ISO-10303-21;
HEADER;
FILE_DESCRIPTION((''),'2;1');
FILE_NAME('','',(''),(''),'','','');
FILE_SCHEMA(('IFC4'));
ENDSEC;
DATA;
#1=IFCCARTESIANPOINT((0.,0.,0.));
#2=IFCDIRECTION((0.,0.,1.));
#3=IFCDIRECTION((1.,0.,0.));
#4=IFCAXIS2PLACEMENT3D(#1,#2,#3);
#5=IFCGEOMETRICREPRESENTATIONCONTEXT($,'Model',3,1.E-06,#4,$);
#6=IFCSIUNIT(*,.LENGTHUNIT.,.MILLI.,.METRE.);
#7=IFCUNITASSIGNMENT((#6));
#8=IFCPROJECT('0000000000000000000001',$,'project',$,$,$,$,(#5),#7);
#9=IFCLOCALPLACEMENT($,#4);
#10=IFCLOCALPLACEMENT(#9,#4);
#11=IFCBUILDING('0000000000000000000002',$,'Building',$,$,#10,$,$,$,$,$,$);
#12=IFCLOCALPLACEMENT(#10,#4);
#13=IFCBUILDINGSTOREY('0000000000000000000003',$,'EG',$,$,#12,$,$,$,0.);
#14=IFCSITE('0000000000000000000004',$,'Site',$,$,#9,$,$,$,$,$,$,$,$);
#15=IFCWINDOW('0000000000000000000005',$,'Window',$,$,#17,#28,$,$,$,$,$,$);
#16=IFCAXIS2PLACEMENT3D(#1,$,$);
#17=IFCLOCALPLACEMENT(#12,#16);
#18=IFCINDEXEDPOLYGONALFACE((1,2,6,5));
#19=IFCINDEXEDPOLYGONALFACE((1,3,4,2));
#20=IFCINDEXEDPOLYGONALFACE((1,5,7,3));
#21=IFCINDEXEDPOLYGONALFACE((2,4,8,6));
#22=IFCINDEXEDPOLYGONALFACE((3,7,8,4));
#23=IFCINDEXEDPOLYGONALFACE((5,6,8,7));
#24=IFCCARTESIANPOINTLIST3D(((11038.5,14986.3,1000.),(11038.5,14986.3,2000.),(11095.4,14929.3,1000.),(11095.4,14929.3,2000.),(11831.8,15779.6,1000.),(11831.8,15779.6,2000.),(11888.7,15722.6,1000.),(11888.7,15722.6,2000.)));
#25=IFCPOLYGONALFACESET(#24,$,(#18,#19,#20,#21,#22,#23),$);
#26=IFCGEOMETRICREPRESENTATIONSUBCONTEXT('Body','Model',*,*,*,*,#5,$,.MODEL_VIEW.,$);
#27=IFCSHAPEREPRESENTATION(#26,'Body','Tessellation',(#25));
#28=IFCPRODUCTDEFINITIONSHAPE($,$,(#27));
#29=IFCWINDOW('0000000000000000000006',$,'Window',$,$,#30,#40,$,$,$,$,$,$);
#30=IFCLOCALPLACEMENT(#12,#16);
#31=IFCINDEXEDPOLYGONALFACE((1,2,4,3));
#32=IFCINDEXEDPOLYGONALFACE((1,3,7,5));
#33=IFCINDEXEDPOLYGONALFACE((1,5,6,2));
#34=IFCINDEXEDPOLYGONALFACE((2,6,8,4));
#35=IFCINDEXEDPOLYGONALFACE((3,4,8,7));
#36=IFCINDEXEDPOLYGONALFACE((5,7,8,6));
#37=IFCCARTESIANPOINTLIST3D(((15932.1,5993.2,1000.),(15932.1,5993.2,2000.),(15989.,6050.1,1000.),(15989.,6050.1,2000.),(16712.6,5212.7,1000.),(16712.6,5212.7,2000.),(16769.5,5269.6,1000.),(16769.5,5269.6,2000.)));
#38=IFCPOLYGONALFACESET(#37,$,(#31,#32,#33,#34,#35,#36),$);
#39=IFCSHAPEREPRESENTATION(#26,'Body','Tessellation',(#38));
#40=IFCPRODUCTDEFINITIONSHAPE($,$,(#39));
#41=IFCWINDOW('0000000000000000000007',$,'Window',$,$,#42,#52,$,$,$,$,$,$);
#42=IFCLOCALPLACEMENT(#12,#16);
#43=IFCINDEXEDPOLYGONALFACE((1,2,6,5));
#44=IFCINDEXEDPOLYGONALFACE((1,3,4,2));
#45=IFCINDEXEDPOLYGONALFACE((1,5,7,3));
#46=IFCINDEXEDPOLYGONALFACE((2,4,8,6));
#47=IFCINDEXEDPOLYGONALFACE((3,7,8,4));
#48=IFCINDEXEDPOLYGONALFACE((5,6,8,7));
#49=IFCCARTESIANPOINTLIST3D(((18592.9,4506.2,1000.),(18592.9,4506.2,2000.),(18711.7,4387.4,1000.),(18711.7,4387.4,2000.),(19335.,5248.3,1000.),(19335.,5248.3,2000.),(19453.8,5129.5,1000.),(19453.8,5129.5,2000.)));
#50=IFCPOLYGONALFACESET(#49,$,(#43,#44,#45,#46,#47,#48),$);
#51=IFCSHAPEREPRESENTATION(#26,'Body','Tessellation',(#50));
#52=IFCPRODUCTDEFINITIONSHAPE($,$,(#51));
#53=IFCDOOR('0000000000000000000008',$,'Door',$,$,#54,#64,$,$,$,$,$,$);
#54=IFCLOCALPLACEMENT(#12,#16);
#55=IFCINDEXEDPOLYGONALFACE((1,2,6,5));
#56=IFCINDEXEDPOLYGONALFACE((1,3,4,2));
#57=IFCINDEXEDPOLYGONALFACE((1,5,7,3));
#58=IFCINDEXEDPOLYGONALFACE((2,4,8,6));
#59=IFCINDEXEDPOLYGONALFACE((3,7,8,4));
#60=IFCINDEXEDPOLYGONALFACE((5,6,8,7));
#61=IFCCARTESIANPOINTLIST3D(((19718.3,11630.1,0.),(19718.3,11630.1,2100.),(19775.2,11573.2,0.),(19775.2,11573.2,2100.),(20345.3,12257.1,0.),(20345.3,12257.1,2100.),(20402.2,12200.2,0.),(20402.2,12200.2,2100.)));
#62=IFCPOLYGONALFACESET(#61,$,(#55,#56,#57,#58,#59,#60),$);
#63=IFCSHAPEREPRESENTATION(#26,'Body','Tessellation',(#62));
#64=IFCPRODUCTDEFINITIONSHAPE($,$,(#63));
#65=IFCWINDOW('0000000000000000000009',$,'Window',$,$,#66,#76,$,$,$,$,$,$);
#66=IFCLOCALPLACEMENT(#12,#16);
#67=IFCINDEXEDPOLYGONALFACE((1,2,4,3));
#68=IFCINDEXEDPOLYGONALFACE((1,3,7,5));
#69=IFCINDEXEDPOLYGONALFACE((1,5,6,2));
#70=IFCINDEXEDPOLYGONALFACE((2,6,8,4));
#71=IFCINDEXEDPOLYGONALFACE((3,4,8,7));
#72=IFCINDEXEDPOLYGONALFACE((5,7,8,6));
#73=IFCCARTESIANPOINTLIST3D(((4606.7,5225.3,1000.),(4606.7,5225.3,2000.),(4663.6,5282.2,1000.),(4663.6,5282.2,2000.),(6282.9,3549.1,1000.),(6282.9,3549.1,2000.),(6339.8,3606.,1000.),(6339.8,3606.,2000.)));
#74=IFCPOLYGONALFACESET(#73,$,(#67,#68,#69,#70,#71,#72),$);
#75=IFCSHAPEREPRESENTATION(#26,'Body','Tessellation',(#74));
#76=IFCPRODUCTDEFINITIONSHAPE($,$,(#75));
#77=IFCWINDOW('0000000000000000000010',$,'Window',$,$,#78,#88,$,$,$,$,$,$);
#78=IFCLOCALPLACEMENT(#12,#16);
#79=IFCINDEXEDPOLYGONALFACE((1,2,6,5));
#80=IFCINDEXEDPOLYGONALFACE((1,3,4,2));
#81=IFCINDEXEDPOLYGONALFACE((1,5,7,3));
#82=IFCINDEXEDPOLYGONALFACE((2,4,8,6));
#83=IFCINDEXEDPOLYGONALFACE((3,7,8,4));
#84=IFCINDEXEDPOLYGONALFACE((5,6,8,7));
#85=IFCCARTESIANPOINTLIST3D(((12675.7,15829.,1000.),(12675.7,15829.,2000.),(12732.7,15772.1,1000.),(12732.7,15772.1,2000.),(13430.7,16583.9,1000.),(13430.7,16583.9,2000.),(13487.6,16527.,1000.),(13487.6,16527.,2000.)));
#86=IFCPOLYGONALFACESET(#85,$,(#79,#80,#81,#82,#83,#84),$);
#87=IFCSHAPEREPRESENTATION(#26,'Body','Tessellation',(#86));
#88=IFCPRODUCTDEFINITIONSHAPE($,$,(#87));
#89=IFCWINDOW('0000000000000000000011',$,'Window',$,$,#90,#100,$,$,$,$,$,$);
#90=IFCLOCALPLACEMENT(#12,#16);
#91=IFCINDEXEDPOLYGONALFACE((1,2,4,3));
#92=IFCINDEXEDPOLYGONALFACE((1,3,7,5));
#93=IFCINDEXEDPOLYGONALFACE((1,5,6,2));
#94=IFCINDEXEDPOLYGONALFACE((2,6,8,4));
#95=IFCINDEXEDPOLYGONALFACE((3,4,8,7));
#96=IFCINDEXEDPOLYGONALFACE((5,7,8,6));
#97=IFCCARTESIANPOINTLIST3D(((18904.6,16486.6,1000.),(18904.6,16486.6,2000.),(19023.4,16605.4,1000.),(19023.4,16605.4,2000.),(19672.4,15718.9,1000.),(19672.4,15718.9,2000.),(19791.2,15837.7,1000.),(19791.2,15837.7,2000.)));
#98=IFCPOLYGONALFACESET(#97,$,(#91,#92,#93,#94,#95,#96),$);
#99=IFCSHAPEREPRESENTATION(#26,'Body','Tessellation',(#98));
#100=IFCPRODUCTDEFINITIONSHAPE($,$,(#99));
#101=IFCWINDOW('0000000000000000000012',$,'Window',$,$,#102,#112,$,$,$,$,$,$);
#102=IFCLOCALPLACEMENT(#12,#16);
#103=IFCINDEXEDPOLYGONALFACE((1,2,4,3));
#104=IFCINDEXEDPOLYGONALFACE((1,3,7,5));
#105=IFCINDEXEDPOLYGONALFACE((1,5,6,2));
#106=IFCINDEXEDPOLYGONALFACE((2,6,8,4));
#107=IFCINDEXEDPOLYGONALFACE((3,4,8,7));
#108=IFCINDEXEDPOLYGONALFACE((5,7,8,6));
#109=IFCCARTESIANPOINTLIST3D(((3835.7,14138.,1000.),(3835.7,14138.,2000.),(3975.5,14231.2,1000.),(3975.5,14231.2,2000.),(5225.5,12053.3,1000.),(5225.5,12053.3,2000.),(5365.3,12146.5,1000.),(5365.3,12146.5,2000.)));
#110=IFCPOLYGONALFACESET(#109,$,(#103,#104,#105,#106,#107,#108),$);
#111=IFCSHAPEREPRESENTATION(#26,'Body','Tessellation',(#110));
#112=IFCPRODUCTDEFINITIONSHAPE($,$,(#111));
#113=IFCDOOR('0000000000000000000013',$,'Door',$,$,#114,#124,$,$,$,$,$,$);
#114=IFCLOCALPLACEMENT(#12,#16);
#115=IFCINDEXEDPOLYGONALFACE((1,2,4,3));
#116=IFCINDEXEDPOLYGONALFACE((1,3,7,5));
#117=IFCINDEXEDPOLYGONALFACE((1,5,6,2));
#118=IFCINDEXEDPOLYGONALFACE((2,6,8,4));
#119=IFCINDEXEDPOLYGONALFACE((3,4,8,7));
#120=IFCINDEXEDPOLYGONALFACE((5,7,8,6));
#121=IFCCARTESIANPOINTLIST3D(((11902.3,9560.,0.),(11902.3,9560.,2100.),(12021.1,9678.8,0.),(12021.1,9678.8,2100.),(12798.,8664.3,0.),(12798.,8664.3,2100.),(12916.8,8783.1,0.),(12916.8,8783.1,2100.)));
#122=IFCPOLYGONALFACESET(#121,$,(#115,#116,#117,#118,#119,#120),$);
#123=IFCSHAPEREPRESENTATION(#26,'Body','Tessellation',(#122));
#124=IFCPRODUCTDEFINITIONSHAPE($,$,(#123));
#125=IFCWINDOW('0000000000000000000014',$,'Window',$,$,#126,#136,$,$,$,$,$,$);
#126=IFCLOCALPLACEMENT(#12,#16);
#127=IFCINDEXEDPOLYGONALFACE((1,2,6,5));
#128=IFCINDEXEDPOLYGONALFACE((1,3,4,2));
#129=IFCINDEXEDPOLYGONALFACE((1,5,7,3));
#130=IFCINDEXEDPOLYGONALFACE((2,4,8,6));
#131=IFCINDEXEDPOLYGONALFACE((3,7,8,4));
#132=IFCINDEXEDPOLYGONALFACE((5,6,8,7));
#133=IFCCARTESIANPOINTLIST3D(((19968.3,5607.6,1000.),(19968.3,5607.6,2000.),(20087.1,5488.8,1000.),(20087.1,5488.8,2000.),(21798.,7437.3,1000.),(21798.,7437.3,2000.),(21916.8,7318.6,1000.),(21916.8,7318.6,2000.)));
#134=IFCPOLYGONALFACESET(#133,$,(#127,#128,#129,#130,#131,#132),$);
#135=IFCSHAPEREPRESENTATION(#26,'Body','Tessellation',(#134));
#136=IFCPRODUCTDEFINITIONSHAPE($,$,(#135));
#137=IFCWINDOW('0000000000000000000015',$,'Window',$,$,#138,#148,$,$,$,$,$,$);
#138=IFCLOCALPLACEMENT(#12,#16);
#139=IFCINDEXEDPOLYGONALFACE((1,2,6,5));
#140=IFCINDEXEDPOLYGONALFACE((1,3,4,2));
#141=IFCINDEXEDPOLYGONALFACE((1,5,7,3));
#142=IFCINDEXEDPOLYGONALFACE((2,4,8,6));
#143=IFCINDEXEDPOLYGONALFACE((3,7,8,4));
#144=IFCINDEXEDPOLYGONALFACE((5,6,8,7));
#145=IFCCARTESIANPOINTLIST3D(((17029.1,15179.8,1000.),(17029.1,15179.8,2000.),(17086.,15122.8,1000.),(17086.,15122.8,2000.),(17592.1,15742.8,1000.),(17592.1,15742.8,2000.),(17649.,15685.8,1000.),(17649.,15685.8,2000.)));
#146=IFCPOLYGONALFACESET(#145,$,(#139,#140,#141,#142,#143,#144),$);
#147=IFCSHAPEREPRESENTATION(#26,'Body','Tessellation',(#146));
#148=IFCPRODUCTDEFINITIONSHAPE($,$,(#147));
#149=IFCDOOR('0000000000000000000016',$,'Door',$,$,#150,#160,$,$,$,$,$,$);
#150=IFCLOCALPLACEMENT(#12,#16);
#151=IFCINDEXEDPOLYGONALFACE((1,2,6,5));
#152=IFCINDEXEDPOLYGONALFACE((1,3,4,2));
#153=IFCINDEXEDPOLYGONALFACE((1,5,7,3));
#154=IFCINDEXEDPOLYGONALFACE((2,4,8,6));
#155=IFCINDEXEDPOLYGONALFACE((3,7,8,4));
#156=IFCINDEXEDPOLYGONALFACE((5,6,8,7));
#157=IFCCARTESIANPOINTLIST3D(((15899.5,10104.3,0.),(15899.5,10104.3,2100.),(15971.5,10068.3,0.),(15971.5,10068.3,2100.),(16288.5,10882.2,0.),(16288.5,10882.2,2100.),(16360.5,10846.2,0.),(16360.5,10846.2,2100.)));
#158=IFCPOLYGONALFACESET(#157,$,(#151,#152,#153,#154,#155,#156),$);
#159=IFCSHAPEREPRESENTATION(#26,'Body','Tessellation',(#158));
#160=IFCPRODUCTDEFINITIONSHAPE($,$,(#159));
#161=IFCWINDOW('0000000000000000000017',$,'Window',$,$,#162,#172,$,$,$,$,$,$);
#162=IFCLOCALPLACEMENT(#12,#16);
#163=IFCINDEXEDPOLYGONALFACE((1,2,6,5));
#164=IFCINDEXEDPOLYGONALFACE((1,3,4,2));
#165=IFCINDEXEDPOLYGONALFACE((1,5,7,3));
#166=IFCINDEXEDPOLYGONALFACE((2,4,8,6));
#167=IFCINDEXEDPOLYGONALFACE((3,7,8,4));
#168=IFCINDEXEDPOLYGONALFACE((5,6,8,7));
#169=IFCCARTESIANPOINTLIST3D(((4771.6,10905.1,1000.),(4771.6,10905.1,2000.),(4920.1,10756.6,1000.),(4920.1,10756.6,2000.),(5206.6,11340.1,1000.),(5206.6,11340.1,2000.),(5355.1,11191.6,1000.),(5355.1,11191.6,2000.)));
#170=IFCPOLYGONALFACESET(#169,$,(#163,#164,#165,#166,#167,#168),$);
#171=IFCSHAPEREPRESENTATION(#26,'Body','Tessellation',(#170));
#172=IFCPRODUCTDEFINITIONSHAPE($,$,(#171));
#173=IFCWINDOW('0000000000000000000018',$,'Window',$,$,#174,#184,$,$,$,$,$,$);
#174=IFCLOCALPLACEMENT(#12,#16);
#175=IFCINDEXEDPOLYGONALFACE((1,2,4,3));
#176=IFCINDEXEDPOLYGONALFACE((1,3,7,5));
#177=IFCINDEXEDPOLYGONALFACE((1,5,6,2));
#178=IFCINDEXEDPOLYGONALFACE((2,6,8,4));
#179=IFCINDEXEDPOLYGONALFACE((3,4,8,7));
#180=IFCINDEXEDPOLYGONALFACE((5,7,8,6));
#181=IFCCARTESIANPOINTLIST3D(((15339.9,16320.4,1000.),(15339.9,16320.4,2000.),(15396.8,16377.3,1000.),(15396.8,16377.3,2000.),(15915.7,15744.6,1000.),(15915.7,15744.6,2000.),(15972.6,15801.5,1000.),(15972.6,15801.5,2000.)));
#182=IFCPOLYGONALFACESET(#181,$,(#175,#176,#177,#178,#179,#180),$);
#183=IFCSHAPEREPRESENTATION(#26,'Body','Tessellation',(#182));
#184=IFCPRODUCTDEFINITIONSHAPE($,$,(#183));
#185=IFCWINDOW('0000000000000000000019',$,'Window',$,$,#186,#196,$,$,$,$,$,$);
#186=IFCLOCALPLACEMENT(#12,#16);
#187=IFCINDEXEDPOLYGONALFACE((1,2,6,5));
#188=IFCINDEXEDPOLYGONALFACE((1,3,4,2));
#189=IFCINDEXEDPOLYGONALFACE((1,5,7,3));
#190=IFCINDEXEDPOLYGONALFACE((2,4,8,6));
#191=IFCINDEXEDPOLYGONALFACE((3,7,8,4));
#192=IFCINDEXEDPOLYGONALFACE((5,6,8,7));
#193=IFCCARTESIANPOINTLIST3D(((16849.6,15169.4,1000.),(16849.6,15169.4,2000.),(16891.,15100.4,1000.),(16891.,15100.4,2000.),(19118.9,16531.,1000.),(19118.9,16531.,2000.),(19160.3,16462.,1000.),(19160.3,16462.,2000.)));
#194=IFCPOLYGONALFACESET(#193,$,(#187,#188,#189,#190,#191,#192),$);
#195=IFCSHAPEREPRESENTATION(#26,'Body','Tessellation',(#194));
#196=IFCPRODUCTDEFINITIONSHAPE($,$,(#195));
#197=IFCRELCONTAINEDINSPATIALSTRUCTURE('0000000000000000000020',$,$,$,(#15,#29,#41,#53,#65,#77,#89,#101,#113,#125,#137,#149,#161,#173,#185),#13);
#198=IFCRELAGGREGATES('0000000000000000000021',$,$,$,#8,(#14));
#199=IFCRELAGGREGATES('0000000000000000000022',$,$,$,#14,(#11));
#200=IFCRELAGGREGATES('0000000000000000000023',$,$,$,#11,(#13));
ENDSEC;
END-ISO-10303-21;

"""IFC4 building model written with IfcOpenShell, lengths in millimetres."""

from ifc_helpers import new_model, si_unit, frame, origin_with_axes, place, context, subcontext, project, spatial, rectangle, extrude, element, save


model = new_model("IFC4")

# Units and contexts
model_context = context("Model", 3, precision=1e-06, world=origin_with_axes())
body_context = subcontext(model_context, "Body", "Model", "MODEL_VIEW")
ifc_project = project(units=[si_unit("LENGTHUNIT", "METRE", prefix="MILLI")], contexts=[model_context])

# Site, building, storey
site_placement = place(None, origin_with_axes())
site = spatial("IfcSite", under=ifc_project, at=site_placement, Name="Site")
building_placement = place(site_placement, origin_with_axes())
building = spatial("IfcBuilding", under=site, at=building_placement, Name="Building")
storey_placement = place(building_placement, origin_with_axes())
storey = spatial("IfcBuildingStorey", under=building, at=storey_placement, Name="EG", Elevation=0.0)

# Windows
window_1_placement = place(storey_placement, origin_with_axes())
element("IfcWindow", 1, at=window_1_placement, inside=storey, Name="Window", context=body_context, shape_type="SweptSolid", body=[
    extrude(rectangle(XDim=1121.9, YDim=80.5), frame((11463.6, 15354.5, 1000.0), z_axis=(0.0, 0.0, 1.0), x_axis=(-0.707107, -0.707107, 0.0)), (0.0, 0.0, 1.0), 1000.0),
])
window_2_placement = place(storey_placement, origin_with_axes())
element("IfcWindow", 2, at=window_2_placement, inside=storey, Name="Window", context=body_context, shape_type="SweptSolid", body=[
    extrude(rectangle(XDim=1103.8, YDim=80.5), frame((16350.8, 5631.4, 1000.0), z_axis=(0.0, 0.0, 1.0), x_axis=(-0.707107, 0.707107, 0.0)), (0.0, 0.0, 1.0), 1000.0),
])
window_3_placement = place(storey_placement, origin_with_axes())
element("IfcWindow", 3, at=window_3_placement, inside=storey, Name="Window", context=body_context, shape_type="SweptSolid", body=[
    extrude(rectangle(XDim=1049.5, YDim=168.0), frame((19023.3, 4817.9, 1000.0), z_axis=(0.0, 0.0, 1.0), x_axis=(-0.707107, -0.707107, 0.0)), (0.0, 0.0, 1.0), 1000.0),
])

# Door
door_1_placement = place(storey_placement, origin_with_axes())
element("IfcDoor", 4, at=door_1_placement, inside=storey, Name="Door", context=body_context, shape_type="SweptSolid", body=[
    extrude(rectangle(XDim=886.7, YDim=80.5), frame((20060.3, 11915.1, 0.0), z_axis=(0.0, 0.0, 1.0), x_axis=(0.707107, 0.707107, 0.0)), (0.0, 0.0, 1.0), 2100.0),
])

# Windows
window_4_placement = place(storey_placement, origin_with_axes())
element("IfcWindow", 5, at=window_4_placement, inside=storey, Name="Window", context=body_context, shape_type="SweptSolid", body=[
    extrude(rectangle(XDim=2370.5, YDim=80.5), frame((5473.2, 4415.6, 1000.0), z_axis=(0.0, 0.0, 1.0), x_axis=(0.707107, -0.707107, 0.0)), (0.0, 0.0, 1.0), 1000.0),
])
window_5_placement = place(storey_placement, origin_with_axes())
element("IfcWindow", 6, at=window_5_placement, inside=storey, Name="Window", context=body_context, shape_type="SweptSolid", body=[
    extrude(rectangle(XDim=1067.6, YDim=80.5), frame((13081.7, 16178.0, 1000.0), z_axis=(0.0, 0.0, 1.0), x_axis=(0.707107, 0.707107, 0.0)), (0.0, 0.0, 1.0), 1000.0),
])
window_6_placement = place(storey_placement, origin_with_axes())
element("IfcWindow", 7, at=window_6_placement, inside=storey, Name="Window", context=body_context, shape_type="SweptSolid", body=[
    extrude(rectangle(XDim=1085.7, YDim=168.0), frame((19347.9, 16162.1, 1000.0), z_axis=(0.0, 0.0, 1.0), x_axis=(-0.707107, 0.707107, 0.0)), (0.0, 0.0, 1.0), 1000.0),
])
window_7_placement = place(storey_placement, origin_with_axes())
element("IfcWindow", 8, at=window_7_placement, inside=storey, Name="Window", context=body_context, shape_type="SweptSolid", body=[
    extrude(rectangle(XDim=2505.5, YDim=168.0), frame((4600.5, 13142.3, 1000.0), z_axis=(0.0, 0.0, 1.0), x_axis=(-0.5547, 0.83205, 0.0)), (0.0, 0.0, 1.0), 1000.0),
])

# Door
door_2_placement = place(storey_placement, origin_with_axes())
element("IfcDoor", 9, at=door_2_placement, inside=storey, Name="Door", context=body_context, shape_type="SweptSolid", body=[
    extrude(rectangle(XDim=1266.7, YDim=168.0), frame((12409.5, 9171.5, 0.0), z_axis=(0.0, 0.0, 1.0), x_axis=(0.707107, -0.707107, 0.0)), (0.0, 0.0, 1.0), 2100.0),
])

# Windows
window_8_placement = place(storey_placement, origin_with_axes())
element("IfcWindow", 10, at=window_8_placement, inside=storey, Name="Window", context=body_context, shape_type="SweptSolid", body=[
    extrude(rectangle(XDim=2587.6, YDim=168.0), frame((20942.5, 6463.1, 1000.0), z_axis=(0.0, 0.0, 1.0), x_axis=(-0.707107, -0.707107, 0.0)), (0.0, 0.0, 1.0), 1000.0),
])
window_9_placement = place(storey_placement, origin_with_axes())
element("IfcWindow", 11, at=window_9_placement, inside=storey, Name="Window", context=body_context, shape_type="SweptSolid", body=[
    extrude(rectangle(XDim=796.2, YDim=80.5), frame((17339.0, 15432.8, 1000.0), z_axis=(0.0, 0.0, 1.0), x_axis=(-0.707107, -0.707107, 0.0)), (0.0, 0.0, 1.0), 1000.0),
])

# Door
door_3_placement = place(storey_placement, origin_with_axes())
element("IfcDoor", 12, at=door_3_placement, inside=storey, Name="Door", context=body_context, shape_type="SweptSolid", body=[
    extrude(rectangle(XDim=869.8, YDim=80.5), frame((16130.0, 10475.2, 0.0), z_axis=(0.0, 0.0, 1.0), x_axis=(0.447214, 0.894427, 0.0)), (0.0, 0.0, 1.0), 2100.0),
])

# Windows
window_10_placement = place(storey_placement, origin_with_axes())
element("IfcWindow", 13, at=window_10_placement, inside=storey, Name="Window", context=body_context, shape_type="SweptSolid", body=[
    extrude(rectangle(XDim=615.2, YDim=210.0), frame((5063.4, 11048.4, 1000.0), z_axis=(0.0, 0.0, 1.0), x_axis=(-0.707107, -0.707107, 0.0)), (0.0, 0.0, 1.0), 1000.0),
])
window_11_placement = place(storey_placement, origin_with_axes())
element("IfcWindow", 14, at=window_11_placement, inside=storey, Name="Window", context=body_context, shape_type="SweptSolid", body=[
    extrude(rectangle(XDim=814.3, YDim=80.5), frame((15656.2, 16061.0, 1000.0), z_axis=(0.0, 0.0, 1.0), x_axis=(-0.707107, 0.707107, 0.0)), (0.0, 0.0, 1.0), 1000.0),
])
window_12_placement = place(storey_placement, origin_with_axes())
element("IfcWindow", 15, at=window_12_placement, inside=storey, Name="Window", context=body_context, shape_type="SweptSolid", body=[
    extrude(rectangle(XDim=2646.4, YDim=80.5), frame((18005.0, 15815.7, 1000.0), z_axis=(0.0, 0.0, 1.0), x_axis=(0.857493, 0.514496, 0.0)), (0.0, 0.0, 1.0), 1000.0),
])

save(model, "model.ifc")
